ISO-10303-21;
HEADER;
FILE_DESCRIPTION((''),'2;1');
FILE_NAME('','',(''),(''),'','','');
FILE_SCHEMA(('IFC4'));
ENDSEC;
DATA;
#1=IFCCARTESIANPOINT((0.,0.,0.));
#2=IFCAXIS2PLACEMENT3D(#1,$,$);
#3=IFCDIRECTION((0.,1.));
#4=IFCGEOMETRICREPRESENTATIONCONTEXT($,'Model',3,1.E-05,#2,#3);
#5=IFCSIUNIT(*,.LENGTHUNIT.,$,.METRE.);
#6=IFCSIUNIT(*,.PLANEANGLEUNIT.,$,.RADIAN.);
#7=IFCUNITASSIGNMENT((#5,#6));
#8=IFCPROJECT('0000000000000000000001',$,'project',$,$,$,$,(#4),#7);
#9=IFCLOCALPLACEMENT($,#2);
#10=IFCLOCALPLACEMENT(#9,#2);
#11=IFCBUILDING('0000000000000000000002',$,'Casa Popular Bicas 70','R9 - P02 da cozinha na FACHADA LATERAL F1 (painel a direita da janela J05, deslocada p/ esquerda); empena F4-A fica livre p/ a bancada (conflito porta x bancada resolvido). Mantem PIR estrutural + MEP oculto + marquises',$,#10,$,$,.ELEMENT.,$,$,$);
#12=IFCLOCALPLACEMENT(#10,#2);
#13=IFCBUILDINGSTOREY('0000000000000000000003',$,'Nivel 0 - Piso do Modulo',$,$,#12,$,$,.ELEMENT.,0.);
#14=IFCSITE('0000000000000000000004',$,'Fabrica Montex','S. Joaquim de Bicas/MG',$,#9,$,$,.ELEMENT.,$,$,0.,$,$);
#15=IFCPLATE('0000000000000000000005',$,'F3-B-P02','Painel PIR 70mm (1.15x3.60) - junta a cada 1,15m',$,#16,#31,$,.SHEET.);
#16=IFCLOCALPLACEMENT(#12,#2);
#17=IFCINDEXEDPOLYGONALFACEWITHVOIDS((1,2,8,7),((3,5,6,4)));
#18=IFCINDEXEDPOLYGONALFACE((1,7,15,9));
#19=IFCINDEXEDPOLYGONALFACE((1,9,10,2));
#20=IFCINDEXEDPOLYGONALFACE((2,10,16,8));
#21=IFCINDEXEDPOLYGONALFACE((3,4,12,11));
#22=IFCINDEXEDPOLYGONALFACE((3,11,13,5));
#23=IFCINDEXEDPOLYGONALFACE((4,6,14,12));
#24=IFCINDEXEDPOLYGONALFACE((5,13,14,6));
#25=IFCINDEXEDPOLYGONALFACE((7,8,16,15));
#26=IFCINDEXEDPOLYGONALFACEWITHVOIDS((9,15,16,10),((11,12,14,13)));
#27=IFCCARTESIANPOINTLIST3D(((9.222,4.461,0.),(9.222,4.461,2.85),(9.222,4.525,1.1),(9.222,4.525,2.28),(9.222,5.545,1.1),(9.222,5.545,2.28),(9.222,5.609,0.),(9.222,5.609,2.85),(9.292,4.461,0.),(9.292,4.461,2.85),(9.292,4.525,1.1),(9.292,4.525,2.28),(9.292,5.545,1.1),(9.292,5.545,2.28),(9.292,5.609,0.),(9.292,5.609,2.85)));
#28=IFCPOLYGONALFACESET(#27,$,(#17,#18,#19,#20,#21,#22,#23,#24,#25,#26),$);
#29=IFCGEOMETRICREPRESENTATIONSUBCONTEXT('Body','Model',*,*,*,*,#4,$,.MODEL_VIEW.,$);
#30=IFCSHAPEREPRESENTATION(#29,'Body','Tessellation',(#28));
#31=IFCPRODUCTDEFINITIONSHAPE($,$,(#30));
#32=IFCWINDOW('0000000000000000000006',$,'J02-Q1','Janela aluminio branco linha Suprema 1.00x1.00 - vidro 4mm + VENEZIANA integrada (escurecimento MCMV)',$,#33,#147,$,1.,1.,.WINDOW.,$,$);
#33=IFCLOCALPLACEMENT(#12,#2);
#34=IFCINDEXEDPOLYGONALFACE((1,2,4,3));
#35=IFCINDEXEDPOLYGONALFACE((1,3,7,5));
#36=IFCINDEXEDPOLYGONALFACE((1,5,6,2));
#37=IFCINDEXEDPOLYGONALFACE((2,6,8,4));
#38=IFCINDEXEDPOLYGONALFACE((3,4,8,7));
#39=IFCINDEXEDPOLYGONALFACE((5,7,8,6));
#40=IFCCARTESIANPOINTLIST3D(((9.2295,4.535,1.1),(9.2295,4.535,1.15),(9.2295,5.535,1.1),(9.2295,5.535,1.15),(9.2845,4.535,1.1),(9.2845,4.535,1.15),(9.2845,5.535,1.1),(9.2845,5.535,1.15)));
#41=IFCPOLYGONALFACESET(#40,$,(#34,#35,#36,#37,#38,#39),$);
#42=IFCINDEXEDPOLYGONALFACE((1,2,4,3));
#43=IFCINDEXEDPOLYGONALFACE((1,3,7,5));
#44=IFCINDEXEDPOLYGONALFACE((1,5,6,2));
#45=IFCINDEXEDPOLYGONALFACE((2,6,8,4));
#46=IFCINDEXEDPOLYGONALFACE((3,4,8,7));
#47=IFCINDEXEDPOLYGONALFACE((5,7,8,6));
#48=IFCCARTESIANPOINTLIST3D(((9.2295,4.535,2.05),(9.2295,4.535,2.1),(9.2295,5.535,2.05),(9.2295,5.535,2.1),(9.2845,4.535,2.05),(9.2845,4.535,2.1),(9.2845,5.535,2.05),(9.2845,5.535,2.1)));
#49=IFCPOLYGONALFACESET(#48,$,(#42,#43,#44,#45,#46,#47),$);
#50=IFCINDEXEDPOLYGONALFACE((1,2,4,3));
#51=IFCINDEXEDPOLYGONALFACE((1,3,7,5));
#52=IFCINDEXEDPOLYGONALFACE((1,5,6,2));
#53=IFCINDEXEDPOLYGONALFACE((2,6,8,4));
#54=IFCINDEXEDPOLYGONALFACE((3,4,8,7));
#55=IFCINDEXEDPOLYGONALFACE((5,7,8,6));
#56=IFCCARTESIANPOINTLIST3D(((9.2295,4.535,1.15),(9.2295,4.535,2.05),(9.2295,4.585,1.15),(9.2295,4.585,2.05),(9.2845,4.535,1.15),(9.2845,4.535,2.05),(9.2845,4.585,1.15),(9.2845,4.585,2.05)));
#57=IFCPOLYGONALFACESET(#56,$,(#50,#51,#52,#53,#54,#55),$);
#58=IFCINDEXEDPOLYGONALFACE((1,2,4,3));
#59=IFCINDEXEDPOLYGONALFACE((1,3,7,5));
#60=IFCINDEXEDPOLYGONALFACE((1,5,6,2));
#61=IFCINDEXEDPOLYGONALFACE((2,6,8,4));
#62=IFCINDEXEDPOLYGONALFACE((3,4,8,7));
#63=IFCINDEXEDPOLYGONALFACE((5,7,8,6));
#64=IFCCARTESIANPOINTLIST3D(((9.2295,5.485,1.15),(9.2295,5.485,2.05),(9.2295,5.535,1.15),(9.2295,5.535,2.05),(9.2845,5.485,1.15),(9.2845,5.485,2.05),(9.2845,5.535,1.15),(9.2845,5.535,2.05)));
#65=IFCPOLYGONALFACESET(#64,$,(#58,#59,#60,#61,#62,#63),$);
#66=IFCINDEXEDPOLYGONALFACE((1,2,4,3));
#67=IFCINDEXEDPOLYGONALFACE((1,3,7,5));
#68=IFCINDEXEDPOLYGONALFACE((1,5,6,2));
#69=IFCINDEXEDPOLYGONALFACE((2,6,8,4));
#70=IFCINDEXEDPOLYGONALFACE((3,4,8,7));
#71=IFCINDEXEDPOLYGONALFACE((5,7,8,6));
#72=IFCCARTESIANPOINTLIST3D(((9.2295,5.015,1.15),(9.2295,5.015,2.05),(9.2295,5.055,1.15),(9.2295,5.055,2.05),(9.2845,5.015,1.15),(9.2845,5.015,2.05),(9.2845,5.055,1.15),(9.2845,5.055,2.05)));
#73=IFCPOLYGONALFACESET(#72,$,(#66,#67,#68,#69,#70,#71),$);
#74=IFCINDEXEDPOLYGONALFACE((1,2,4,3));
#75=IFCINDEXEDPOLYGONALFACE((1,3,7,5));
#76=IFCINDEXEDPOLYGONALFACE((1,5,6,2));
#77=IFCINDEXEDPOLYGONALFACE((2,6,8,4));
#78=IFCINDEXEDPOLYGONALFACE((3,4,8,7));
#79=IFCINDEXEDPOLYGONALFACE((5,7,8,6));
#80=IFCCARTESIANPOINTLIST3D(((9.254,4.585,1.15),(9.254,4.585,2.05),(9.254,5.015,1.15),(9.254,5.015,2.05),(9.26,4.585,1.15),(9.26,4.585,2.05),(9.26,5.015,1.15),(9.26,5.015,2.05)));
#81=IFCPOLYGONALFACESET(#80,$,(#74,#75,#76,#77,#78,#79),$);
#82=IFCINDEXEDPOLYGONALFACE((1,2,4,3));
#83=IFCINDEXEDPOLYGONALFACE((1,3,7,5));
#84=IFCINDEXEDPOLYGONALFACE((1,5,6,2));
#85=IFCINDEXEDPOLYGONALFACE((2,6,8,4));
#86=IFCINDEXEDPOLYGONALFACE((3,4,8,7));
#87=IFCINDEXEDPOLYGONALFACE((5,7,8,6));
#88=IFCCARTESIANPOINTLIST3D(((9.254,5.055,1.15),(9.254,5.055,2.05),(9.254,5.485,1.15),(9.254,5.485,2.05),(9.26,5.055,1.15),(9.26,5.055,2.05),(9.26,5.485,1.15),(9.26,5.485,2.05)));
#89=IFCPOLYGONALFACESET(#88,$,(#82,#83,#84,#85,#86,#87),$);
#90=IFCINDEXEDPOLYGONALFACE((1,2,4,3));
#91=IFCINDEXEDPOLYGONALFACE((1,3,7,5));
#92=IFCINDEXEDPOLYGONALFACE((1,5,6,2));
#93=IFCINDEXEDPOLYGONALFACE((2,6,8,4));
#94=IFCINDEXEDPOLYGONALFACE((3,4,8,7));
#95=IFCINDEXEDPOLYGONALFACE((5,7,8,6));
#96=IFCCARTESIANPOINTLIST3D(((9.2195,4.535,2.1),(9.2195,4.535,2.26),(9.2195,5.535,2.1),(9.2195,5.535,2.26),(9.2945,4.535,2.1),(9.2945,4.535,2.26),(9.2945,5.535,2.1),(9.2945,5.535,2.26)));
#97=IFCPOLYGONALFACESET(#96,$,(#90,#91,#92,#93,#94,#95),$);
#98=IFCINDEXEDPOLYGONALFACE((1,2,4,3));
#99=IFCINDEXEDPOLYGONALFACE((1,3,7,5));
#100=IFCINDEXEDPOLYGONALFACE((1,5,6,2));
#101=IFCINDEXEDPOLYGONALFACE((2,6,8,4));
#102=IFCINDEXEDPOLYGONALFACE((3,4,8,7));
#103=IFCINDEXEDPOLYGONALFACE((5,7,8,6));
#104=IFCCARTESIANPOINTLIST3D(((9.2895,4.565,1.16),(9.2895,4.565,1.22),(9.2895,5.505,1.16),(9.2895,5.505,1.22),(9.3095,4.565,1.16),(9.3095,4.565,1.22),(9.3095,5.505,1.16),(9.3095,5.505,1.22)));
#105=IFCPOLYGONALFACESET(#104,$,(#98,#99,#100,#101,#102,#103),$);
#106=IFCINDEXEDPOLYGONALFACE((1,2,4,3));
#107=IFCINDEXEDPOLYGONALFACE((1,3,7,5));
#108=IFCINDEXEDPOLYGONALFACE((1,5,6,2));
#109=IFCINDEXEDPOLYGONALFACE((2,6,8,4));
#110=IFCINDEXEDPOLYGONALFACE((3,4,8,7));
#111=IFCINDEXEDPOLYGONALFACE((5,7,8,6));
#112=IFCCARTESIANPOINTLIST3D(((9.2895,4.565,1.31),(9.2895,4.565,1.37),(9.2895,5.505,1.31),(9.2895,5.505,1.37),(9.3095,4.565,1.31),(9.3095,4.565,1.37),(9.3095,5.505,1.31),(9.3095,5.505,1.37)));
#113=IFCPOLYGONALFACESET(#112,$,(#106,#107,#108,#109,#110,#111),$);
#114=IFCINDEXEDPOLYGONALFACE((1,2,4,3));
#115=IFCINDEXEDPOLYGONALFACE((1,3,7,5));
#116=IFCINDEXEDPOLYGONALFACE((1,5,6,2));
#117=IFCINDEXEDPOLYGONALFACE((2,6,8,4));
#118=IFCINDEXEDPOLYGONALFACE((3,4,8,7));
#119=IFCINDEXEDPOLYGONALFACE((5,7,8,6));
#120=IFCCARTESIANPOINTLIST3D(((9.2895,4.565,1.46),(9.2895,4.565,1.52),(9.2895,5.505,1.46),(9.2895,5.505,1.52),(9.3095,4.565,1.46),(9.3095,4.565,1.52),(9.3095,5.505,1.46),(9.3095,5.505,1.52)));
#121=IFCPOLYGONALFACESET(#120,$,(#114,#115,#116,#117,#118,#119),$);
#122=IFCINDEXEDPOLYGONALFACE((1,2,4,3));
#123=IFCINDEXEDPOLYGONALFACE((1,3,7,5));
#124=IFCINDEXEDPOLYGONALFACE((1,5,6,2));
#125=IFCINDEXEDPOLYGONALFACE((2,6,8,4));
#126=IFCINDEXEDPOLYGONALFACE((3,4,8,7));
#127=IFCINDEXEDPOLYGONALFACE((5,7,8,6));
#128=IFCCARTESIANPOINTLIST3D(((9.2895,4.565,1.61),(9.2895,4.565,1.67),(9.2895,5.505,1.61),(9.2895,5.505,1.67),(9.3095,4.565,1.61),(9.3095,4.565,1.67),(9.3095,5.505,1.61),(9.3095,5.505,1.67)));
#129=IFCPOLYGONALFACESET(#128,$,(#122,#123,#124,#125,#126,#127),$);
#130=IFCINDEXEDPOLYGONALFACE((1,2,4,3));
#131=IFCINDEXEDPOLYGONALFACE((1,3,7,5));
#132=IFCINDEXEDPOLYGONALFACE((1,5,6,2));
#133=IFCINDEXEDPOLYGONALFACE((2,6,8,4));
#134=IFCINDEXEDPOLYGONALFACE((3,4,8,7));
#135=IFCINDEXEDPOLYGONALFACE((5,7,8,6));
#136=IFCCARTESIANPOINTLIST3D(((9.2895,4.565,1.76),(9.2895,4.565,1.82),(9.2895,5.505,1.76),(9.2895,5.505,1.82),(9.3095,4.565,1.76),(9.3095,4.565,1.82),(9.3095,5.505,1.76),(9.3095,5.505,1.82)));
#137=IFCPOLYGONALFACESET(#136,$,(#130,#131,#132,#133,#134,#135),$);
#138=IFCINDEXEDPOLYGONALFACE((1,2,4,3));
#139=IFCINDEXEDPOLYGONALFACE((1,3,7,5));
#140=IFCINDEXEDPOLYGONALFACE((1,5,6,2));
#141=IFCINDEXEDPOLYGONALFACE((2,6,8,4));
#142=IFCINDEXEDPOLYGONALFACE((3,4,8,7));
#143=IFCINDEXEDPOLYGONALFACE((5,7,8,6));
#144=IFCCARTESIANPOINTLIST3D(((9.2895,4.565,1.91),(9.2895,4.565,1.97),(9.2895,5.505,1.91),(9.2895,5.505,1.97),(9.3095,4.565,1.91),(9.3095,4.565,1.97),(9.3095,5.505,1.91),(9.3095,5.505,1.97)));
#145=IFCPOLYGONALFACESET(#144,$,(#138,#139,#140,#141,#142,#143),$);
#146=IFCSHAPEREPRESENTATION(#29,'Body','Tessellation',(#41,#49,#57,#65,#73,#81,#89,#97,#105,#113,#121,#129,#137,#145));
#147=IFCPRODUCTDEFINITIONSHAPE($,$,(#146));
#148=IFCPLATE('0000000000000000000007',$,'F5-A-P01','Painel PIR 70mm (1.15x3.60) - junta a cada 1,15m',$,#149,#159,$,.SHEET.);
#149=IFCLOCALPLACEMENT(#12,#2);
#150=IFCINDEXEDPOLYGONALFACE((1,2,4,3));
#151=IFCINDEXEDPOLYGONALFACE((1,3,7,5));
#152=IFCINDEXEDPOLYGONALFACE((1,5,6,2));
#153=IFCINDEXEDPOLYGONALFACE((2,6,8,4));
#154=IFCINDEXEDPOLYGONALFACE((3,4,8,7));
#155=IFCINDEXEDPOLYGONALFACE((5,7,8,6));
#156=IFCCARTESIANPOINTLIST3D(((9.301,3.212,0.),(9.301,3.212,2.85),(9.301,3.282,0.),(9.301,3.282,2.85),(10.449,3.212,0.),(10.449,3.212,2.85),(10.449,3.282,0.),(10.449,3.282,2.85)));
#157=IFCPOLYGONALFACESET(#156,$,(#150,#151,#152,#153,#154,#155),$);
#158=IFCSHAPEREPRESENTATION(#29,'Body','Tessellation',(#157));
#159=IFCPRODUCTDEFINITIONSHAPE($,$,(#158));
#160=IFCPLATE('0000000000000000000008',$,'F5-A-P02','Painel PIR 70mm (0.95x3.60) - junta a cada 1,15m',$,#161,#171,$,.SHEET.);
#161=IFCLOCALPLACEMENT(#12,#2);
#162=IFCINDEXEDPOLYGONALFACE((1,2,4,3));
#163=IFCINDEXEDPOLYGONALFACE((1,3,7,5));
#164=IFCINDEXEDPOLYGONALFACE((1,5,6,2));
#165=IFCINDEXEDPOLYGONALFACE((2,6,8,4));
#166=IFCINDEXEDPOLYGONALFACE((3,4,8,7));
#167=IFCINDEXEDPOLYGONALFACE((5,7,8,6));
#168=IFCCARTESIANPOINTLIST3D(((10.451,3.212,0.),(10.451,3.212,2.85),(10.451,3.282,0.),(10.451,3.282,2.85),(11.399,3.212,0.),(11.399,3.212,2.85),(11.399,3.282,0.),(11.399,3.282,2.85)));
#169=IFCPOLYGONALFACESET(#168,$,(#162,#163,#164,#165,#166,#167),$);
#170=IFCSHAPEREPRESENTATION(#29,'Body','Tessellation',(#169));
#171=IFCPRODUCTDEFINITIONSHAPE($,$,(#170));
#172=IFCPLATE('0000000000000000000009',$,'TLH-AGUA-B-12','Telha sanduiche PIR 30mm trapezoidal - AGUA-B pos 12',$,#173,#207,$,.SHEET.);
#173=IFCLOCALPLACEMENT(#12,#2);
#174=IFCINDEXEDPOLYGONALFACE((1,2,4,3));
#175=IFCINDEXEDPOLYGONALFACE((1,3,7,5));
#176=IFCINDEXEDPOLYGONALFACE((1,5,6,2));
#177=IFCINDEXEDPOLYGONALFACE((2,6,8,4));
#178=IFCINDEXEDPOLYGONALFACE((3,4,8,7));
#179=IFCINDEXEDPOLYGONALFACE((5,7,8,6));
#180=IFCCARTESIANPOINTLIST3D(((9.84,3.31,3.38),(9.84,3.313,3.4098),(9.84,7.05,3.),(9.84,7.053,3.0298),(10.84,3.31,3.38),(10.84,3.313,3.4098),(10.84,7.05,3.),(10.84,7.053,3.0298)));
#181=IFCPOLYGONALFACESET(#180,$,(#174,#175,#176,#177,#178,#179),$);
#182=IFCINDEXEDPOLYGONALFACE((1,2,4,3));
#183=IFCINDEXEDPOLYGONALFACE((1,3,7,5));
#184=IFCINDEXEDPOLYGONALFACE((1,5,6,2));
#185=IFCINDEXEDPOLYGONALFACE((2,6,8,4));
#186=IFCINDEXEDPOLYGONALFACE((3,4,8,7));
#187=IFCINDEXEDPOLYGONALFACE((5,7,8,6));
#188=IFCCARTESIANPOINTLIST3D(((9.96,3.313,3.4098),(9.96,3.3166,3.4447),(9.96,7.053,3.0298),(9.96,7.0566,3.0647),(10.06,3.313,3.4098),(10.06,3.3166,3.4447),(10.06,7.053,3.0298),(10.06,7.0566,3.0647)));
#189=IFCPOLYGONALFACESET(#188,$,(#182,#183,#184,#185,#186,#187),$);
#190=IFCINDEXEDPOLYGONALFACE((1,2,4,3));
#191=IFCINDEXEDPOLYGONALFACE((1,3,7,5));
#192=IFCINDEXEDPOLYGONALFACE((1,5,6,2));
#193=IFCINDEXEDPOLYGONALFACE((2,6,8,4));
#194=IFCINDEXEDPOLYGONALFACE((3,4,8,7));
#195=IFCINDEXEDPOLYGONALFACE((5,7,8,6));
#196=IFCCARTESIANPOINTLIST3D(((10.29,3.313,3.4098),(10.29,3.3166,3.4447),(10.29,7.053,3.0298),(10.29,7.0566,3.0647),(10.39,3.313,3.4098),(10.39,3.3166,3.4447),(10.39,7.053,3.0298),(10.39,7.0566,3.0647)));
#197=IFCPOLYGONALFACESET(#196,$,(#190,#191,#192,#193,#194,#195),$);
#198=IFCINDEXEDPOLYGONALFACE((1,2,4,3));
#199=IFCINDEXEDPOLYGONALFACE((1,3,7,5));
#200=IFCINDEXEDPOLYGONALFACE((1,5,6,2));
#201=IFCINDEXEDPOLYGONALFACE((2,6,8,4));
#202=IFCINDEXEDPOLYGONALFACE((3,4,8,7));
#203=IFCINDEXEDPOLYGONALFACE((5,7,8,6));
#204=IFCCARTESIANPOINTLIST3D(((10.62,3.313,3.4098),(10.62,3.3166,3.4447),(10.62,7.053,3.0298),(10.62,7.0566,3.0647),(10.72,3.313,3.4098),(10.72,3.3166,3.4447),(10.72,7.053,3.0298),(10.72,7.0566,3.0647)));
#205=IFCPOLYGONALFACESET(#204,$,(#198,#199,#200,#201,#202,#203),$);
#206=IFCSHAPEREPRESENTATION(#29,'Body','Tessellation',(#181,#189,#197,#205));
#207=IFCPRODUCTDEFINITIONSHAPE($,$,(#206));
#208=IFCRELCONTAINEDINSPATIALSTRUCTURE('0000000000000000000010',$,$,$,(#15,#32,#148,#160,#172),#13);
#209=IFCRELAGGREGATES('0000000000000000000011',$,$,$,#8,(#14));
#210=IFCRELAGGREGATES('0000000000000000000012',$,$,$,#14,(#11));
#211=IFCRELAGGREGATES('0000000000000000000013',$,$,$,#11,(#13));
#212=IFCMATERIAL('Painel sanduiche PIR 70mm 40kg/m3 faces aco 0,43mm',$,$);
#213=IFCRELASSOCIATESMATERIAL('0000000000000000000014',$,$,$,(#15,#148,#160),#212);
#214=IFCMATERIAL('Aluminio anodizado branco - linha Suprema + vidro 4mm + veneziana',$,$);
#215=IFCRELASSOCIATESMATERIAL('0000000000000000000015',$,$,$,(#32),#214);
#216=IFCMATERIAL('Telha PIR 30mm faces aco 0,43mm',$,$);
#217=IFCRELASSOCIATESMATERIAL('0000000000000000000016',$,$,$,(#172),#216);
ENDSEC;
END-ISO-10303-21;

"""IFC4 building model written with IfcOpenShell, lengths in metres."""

from ifc_helpers import new_model, si_unit, direction, frame, frame_2d, origin, place, context, subcontext, project, spatial, rectangle, extrude, material, element, fill, save


model = new_model("IFC4")

# Units and contexts
model_context = context("Model", 3, precision=1e-05, world=origin(), true_north=direction((0.0, 1.0)))
body_context = subcontext(model_context, "Body", "Model", "MODEL_VIEW")
ifc_project = project(units=[si_unit("LENGTHUNIT", "METRE"), si_unit("PLANEANGLEUNIT", "RADIAN")], contexts=[model_context])

# Site, building, storey
site_placement = place(None, origin())
site = spatial("IfcSite", under=ifc_project, at=site_placement, Name="Fabrica Montex", Description="S. Joaquim de Bicas/MG", CompositionType="ELEMENT", RefElevation=0.0)
building_placement = place(site_placement, origin())
building = spatial("IfcBuilding", under=site, at=building_placement, Name="Casa Popular Bicas 70", Description="R9 - P02 da cozinha na FACHADA LATERAL F1 (painel a direita da janela J05, deslocada p/ esquerda); empena F4-A fica livre p/ a bancada (conflito porta x bancada resolvido). Mantem PIR estrutural + MEP oculto + marquises", CompositionType="ELEMENT")
storey_placement = place(building_placement, origin())
storey = spatial("IfcBuildingStorey", under=building, at=storey_placement, Name="Nivel 0 - Piso do Modulo", CompositionType="ELEMENT", Elevation=0.0)

# Shared definitions
ifc_material_1 = material(Name="Painel sanduiche PIR 70mm 40kg/m3 faces aco 0,43mm")

# Plate, opening, window
plate_1_placement = place(storey_placement, frame((9.257, 4.461, 0.0), x_axis=(0.0, 1.0, 0.0)))
plate_1 = element("IfcPlate", 1, at=plate_1_placement, inside=storey, material=ifc_material_1, Name="F3-B-P02", Description="Painel PIR 70mm (1.15x3.60) - junta a cada 1,15m", PredefinedType="SHEET", context=body_context, shape_type="SweptSolid", body=[
    extrude(rectangle(XDim=1.148, YDim=0.07, at=frame_2d((0.574, 0.0))), origin(), (0.0, 0.0, 1.0), 2.85),
])
opening_1_placement = place(storey_placement, frame((9.257, 4.535, 1.1), x_axis=(0.0, 1.0, 0.0)))
opening_1 = element("IfcOpeningElement", 2, at=opening_1_placement, cuts=plate_1, PredefinedType="OPENING", context=body_context, shape_type="SweptSolid", body=[
    extrude(rectangle(XDim=1.02, YDim=0.3, at=frame_2d((0.5, 0.0))), origin(), (0.0, 0.0, 1.0), 1.18),
])
ifc_material_2 = material(Name="Aluminio anodizado branco - linha Suprema + vidro 4mm + veneziana")
window_placement = place(storey_placement, frame((9.257, 4.535, 1.1), x_axis=(0.0, 1.0, 0.0)))
window = element("IfcWindow", 3, at=window_placement, inside=storey, material=ifc_material_2, Name="J02-Q1", Description="Janela aluminio branco linha Suprema 1.00x1.00 - vidro 4mm + VENEZIANA integrada (escurecimento MCMV)", OverallHeight=1.0, OverallWidth=1.0, PredefinedType="WINDOW", context=body_context, shape_type="SweptSolid", body=[
    extrude(rectangle(XDim=1.0, YDim=0.055, at=frame_2d((0.5, 0.0))), origin(), (0.0, 0.0, 1.0), 0.05),
    extrude(rectangle(XDim=1.0, YDim=0.055, at=frame_2d((0.5, 0.0))), frame((0.0, 0.0, 0.95)), (0.0, 0.0, 1.0), 0.05),
    extrude(rectangle(XDim=0.05, YDim=0.055, at=frame_2d((0.025, 0.0))), frame((0.0, 0.0, 0.05)), (0.0, 0.0, 1.0), 0.9),
    extrude(rectangle(XDim=0.05, YDim=0.055, at=frame_2d((0.975, 0.0))), frame((0.0, 0.0, 0.05)), (0.0, 0.0, 1.0), 0.9),
    extrude(rectangle(XDim=0.04, YDim=0.055, at=frame_2d((0.5, 0.0))), frame((0.0, 0.0, 0.05)), (0.0, 0.0, 1.0), 0.9),
    extrude(rectangle(XDim=0.43, YDim=0.006, at=frame_2d((0.265, 0.0))), frame((0.0, 0.0, 0.05)), (0.0, 0.0, 1.0), 0.9),
    extrude(rectangle(XDim=0.43, YDim=0.006, at=frame_2d((0.735, 0.0))), frame((0.0, 0.0, 0.05)), (0.0, 0.0, 1.0), 0.9),
    extrude(rectangle(XDim=1.0, YDim=0.075, at=frame_2d((0.5, 0.0))), frame((0.0, 0.0, 1.0)), (0.0, 0.0, 1.0), 0.16),
    extrude(rectangle(XDim=0.94, YDim=0.02, at=frame_2d((0.5, -0.0425))), frame((0.0, 0.0, 0.06)), (0.0, 0.0, 1.0), 0.06),
    extrude(rectangle(XDim=0.94, YDim=0.02, at=frame_2d((0.5, -0.0425))), frame((0.0, 0.0, 0.21)), (0.0, 0.0, 1.0), 0.06),
    extrude(rectangle(XDim=0.94, YDim=0.02, at=frame_2d((0.5, -0.0425))), frame((0.0, 0.0, 0.36)), (0.0, 0.0, 1.0), 0.06),
    extrude(rectangle(XDim=0.94, YDim=0.02, at=frame_2d((0.5, -0.0425))), frame((0.0, 0.0, 0.51)), (0.0, 0.0, 1.0), 0.06),
    extrude(rectangle(XDim=0.94, YDim=0.02, at=frame_2d((0.5, -0.0425))), frame((0.0, 0.0, 0.66)), (0.0, 0.0, 1.0), 0.06),
    extrude(rectangle(XDim=0.94, YDim=0.02, at=frame_2d((0.5, -0.0425))), frame((0.0, 0.0, 0.81)), (0.0, 0.0, 1.0), 0.06),
])
fill(opening_1, window)

# Plates
plate_2_placement = place(storey_placement, frame((9.301, 3.247, 0.0), x_axis=(1.0, 0.0, 0.0)))
element("IfcPlate", 4, at=plate_2_placement, inside=storey, material=ifc_material_1, Name="F5-A-P01", Description="Painel PIR 70mm (1.15x3.60) - junta a cada 1,15m", PredefinedType="SHEET", context=body_context, shape_type="SweptSolid", body=[
    extrude(rectangle(XDim=1.148, YDim=0.07, at=frame_2d((0.574, 0.0))), origin(), (0.0, 0.0, 1.0), 2.85),
])
plate_3_placement = place(storey_placement, frame((10.451, 3.247, 0.0), x_axis=(1.0, 0.0, 0.0)))
element("IfcPlate", 5, at=plate_3_placement, inside=storey, material=ifc_material_1, Name="F5-A-P02", Description="Painel PIR 70mm (0.95x3.60) - junta a cada 1,15m", PredefinedType="SHEET", context=body_context, shape_type="SweptSolid", body=[
    extrude(rectangle(XDim=0.948, YDim=0.07, at=frame_2d((0.474, 0.0))), origin(), (0.0, 0.0, 1.0), 2.85),
])
ifc_material_3 = material(Name="Telha PIR 30mm faces aco 0,43mm")
for number, where, z_axis, x_axis, name in (
    (6, (9.84, 3.31, 3.38), (0.0, 0.101084, 0.994878), (1.0, 0.0, 0.0), "TLH-AGUA-B-12"),
):
    element("IfcPlate", number, at=place(storey_placement, frame(where, z_axis=z_axis, x_axis=x_axis)), inside=storey, material=ifc_material_3, Name=name, Description="Telha sanduiche PIR 30mm trapezoidal - AGUA-B pos 12", PredefinedType="SHEET", context=body_context, shape_type="SweptSolid", body=[
        extrude(rectangle(XDim=1.0, YDim=3.7593, at=frame_2d((0.5, 1.8796))), origin(), (0.0, 0.0, 1.0), 0.03),
        extrude(rectangle(XDim=0.1, YDim=3.7593, at=frame_2d((0.17, 1.8796))), frame((0.0, 0.0, 0.03)), (0.0, 0.0, 1.0), 0.035),
        extrude(rectangle(XDim=0.1, YDim=3.7593, at=frame_2d((0.5, 1.8796))), frame((0.0, 0.0, 0.03)), (0.0, 0.0, 1.0), 0.035),
        extrude(rectangle(XDim=0.1, YDim=3.7593, at=frame_2d((0.83, 1.8796))), frame((0.0, 0.0, 0.03)), (0.0, 0.0, 1.0), 0.035),
    ])

save(model, "model.ifc")
